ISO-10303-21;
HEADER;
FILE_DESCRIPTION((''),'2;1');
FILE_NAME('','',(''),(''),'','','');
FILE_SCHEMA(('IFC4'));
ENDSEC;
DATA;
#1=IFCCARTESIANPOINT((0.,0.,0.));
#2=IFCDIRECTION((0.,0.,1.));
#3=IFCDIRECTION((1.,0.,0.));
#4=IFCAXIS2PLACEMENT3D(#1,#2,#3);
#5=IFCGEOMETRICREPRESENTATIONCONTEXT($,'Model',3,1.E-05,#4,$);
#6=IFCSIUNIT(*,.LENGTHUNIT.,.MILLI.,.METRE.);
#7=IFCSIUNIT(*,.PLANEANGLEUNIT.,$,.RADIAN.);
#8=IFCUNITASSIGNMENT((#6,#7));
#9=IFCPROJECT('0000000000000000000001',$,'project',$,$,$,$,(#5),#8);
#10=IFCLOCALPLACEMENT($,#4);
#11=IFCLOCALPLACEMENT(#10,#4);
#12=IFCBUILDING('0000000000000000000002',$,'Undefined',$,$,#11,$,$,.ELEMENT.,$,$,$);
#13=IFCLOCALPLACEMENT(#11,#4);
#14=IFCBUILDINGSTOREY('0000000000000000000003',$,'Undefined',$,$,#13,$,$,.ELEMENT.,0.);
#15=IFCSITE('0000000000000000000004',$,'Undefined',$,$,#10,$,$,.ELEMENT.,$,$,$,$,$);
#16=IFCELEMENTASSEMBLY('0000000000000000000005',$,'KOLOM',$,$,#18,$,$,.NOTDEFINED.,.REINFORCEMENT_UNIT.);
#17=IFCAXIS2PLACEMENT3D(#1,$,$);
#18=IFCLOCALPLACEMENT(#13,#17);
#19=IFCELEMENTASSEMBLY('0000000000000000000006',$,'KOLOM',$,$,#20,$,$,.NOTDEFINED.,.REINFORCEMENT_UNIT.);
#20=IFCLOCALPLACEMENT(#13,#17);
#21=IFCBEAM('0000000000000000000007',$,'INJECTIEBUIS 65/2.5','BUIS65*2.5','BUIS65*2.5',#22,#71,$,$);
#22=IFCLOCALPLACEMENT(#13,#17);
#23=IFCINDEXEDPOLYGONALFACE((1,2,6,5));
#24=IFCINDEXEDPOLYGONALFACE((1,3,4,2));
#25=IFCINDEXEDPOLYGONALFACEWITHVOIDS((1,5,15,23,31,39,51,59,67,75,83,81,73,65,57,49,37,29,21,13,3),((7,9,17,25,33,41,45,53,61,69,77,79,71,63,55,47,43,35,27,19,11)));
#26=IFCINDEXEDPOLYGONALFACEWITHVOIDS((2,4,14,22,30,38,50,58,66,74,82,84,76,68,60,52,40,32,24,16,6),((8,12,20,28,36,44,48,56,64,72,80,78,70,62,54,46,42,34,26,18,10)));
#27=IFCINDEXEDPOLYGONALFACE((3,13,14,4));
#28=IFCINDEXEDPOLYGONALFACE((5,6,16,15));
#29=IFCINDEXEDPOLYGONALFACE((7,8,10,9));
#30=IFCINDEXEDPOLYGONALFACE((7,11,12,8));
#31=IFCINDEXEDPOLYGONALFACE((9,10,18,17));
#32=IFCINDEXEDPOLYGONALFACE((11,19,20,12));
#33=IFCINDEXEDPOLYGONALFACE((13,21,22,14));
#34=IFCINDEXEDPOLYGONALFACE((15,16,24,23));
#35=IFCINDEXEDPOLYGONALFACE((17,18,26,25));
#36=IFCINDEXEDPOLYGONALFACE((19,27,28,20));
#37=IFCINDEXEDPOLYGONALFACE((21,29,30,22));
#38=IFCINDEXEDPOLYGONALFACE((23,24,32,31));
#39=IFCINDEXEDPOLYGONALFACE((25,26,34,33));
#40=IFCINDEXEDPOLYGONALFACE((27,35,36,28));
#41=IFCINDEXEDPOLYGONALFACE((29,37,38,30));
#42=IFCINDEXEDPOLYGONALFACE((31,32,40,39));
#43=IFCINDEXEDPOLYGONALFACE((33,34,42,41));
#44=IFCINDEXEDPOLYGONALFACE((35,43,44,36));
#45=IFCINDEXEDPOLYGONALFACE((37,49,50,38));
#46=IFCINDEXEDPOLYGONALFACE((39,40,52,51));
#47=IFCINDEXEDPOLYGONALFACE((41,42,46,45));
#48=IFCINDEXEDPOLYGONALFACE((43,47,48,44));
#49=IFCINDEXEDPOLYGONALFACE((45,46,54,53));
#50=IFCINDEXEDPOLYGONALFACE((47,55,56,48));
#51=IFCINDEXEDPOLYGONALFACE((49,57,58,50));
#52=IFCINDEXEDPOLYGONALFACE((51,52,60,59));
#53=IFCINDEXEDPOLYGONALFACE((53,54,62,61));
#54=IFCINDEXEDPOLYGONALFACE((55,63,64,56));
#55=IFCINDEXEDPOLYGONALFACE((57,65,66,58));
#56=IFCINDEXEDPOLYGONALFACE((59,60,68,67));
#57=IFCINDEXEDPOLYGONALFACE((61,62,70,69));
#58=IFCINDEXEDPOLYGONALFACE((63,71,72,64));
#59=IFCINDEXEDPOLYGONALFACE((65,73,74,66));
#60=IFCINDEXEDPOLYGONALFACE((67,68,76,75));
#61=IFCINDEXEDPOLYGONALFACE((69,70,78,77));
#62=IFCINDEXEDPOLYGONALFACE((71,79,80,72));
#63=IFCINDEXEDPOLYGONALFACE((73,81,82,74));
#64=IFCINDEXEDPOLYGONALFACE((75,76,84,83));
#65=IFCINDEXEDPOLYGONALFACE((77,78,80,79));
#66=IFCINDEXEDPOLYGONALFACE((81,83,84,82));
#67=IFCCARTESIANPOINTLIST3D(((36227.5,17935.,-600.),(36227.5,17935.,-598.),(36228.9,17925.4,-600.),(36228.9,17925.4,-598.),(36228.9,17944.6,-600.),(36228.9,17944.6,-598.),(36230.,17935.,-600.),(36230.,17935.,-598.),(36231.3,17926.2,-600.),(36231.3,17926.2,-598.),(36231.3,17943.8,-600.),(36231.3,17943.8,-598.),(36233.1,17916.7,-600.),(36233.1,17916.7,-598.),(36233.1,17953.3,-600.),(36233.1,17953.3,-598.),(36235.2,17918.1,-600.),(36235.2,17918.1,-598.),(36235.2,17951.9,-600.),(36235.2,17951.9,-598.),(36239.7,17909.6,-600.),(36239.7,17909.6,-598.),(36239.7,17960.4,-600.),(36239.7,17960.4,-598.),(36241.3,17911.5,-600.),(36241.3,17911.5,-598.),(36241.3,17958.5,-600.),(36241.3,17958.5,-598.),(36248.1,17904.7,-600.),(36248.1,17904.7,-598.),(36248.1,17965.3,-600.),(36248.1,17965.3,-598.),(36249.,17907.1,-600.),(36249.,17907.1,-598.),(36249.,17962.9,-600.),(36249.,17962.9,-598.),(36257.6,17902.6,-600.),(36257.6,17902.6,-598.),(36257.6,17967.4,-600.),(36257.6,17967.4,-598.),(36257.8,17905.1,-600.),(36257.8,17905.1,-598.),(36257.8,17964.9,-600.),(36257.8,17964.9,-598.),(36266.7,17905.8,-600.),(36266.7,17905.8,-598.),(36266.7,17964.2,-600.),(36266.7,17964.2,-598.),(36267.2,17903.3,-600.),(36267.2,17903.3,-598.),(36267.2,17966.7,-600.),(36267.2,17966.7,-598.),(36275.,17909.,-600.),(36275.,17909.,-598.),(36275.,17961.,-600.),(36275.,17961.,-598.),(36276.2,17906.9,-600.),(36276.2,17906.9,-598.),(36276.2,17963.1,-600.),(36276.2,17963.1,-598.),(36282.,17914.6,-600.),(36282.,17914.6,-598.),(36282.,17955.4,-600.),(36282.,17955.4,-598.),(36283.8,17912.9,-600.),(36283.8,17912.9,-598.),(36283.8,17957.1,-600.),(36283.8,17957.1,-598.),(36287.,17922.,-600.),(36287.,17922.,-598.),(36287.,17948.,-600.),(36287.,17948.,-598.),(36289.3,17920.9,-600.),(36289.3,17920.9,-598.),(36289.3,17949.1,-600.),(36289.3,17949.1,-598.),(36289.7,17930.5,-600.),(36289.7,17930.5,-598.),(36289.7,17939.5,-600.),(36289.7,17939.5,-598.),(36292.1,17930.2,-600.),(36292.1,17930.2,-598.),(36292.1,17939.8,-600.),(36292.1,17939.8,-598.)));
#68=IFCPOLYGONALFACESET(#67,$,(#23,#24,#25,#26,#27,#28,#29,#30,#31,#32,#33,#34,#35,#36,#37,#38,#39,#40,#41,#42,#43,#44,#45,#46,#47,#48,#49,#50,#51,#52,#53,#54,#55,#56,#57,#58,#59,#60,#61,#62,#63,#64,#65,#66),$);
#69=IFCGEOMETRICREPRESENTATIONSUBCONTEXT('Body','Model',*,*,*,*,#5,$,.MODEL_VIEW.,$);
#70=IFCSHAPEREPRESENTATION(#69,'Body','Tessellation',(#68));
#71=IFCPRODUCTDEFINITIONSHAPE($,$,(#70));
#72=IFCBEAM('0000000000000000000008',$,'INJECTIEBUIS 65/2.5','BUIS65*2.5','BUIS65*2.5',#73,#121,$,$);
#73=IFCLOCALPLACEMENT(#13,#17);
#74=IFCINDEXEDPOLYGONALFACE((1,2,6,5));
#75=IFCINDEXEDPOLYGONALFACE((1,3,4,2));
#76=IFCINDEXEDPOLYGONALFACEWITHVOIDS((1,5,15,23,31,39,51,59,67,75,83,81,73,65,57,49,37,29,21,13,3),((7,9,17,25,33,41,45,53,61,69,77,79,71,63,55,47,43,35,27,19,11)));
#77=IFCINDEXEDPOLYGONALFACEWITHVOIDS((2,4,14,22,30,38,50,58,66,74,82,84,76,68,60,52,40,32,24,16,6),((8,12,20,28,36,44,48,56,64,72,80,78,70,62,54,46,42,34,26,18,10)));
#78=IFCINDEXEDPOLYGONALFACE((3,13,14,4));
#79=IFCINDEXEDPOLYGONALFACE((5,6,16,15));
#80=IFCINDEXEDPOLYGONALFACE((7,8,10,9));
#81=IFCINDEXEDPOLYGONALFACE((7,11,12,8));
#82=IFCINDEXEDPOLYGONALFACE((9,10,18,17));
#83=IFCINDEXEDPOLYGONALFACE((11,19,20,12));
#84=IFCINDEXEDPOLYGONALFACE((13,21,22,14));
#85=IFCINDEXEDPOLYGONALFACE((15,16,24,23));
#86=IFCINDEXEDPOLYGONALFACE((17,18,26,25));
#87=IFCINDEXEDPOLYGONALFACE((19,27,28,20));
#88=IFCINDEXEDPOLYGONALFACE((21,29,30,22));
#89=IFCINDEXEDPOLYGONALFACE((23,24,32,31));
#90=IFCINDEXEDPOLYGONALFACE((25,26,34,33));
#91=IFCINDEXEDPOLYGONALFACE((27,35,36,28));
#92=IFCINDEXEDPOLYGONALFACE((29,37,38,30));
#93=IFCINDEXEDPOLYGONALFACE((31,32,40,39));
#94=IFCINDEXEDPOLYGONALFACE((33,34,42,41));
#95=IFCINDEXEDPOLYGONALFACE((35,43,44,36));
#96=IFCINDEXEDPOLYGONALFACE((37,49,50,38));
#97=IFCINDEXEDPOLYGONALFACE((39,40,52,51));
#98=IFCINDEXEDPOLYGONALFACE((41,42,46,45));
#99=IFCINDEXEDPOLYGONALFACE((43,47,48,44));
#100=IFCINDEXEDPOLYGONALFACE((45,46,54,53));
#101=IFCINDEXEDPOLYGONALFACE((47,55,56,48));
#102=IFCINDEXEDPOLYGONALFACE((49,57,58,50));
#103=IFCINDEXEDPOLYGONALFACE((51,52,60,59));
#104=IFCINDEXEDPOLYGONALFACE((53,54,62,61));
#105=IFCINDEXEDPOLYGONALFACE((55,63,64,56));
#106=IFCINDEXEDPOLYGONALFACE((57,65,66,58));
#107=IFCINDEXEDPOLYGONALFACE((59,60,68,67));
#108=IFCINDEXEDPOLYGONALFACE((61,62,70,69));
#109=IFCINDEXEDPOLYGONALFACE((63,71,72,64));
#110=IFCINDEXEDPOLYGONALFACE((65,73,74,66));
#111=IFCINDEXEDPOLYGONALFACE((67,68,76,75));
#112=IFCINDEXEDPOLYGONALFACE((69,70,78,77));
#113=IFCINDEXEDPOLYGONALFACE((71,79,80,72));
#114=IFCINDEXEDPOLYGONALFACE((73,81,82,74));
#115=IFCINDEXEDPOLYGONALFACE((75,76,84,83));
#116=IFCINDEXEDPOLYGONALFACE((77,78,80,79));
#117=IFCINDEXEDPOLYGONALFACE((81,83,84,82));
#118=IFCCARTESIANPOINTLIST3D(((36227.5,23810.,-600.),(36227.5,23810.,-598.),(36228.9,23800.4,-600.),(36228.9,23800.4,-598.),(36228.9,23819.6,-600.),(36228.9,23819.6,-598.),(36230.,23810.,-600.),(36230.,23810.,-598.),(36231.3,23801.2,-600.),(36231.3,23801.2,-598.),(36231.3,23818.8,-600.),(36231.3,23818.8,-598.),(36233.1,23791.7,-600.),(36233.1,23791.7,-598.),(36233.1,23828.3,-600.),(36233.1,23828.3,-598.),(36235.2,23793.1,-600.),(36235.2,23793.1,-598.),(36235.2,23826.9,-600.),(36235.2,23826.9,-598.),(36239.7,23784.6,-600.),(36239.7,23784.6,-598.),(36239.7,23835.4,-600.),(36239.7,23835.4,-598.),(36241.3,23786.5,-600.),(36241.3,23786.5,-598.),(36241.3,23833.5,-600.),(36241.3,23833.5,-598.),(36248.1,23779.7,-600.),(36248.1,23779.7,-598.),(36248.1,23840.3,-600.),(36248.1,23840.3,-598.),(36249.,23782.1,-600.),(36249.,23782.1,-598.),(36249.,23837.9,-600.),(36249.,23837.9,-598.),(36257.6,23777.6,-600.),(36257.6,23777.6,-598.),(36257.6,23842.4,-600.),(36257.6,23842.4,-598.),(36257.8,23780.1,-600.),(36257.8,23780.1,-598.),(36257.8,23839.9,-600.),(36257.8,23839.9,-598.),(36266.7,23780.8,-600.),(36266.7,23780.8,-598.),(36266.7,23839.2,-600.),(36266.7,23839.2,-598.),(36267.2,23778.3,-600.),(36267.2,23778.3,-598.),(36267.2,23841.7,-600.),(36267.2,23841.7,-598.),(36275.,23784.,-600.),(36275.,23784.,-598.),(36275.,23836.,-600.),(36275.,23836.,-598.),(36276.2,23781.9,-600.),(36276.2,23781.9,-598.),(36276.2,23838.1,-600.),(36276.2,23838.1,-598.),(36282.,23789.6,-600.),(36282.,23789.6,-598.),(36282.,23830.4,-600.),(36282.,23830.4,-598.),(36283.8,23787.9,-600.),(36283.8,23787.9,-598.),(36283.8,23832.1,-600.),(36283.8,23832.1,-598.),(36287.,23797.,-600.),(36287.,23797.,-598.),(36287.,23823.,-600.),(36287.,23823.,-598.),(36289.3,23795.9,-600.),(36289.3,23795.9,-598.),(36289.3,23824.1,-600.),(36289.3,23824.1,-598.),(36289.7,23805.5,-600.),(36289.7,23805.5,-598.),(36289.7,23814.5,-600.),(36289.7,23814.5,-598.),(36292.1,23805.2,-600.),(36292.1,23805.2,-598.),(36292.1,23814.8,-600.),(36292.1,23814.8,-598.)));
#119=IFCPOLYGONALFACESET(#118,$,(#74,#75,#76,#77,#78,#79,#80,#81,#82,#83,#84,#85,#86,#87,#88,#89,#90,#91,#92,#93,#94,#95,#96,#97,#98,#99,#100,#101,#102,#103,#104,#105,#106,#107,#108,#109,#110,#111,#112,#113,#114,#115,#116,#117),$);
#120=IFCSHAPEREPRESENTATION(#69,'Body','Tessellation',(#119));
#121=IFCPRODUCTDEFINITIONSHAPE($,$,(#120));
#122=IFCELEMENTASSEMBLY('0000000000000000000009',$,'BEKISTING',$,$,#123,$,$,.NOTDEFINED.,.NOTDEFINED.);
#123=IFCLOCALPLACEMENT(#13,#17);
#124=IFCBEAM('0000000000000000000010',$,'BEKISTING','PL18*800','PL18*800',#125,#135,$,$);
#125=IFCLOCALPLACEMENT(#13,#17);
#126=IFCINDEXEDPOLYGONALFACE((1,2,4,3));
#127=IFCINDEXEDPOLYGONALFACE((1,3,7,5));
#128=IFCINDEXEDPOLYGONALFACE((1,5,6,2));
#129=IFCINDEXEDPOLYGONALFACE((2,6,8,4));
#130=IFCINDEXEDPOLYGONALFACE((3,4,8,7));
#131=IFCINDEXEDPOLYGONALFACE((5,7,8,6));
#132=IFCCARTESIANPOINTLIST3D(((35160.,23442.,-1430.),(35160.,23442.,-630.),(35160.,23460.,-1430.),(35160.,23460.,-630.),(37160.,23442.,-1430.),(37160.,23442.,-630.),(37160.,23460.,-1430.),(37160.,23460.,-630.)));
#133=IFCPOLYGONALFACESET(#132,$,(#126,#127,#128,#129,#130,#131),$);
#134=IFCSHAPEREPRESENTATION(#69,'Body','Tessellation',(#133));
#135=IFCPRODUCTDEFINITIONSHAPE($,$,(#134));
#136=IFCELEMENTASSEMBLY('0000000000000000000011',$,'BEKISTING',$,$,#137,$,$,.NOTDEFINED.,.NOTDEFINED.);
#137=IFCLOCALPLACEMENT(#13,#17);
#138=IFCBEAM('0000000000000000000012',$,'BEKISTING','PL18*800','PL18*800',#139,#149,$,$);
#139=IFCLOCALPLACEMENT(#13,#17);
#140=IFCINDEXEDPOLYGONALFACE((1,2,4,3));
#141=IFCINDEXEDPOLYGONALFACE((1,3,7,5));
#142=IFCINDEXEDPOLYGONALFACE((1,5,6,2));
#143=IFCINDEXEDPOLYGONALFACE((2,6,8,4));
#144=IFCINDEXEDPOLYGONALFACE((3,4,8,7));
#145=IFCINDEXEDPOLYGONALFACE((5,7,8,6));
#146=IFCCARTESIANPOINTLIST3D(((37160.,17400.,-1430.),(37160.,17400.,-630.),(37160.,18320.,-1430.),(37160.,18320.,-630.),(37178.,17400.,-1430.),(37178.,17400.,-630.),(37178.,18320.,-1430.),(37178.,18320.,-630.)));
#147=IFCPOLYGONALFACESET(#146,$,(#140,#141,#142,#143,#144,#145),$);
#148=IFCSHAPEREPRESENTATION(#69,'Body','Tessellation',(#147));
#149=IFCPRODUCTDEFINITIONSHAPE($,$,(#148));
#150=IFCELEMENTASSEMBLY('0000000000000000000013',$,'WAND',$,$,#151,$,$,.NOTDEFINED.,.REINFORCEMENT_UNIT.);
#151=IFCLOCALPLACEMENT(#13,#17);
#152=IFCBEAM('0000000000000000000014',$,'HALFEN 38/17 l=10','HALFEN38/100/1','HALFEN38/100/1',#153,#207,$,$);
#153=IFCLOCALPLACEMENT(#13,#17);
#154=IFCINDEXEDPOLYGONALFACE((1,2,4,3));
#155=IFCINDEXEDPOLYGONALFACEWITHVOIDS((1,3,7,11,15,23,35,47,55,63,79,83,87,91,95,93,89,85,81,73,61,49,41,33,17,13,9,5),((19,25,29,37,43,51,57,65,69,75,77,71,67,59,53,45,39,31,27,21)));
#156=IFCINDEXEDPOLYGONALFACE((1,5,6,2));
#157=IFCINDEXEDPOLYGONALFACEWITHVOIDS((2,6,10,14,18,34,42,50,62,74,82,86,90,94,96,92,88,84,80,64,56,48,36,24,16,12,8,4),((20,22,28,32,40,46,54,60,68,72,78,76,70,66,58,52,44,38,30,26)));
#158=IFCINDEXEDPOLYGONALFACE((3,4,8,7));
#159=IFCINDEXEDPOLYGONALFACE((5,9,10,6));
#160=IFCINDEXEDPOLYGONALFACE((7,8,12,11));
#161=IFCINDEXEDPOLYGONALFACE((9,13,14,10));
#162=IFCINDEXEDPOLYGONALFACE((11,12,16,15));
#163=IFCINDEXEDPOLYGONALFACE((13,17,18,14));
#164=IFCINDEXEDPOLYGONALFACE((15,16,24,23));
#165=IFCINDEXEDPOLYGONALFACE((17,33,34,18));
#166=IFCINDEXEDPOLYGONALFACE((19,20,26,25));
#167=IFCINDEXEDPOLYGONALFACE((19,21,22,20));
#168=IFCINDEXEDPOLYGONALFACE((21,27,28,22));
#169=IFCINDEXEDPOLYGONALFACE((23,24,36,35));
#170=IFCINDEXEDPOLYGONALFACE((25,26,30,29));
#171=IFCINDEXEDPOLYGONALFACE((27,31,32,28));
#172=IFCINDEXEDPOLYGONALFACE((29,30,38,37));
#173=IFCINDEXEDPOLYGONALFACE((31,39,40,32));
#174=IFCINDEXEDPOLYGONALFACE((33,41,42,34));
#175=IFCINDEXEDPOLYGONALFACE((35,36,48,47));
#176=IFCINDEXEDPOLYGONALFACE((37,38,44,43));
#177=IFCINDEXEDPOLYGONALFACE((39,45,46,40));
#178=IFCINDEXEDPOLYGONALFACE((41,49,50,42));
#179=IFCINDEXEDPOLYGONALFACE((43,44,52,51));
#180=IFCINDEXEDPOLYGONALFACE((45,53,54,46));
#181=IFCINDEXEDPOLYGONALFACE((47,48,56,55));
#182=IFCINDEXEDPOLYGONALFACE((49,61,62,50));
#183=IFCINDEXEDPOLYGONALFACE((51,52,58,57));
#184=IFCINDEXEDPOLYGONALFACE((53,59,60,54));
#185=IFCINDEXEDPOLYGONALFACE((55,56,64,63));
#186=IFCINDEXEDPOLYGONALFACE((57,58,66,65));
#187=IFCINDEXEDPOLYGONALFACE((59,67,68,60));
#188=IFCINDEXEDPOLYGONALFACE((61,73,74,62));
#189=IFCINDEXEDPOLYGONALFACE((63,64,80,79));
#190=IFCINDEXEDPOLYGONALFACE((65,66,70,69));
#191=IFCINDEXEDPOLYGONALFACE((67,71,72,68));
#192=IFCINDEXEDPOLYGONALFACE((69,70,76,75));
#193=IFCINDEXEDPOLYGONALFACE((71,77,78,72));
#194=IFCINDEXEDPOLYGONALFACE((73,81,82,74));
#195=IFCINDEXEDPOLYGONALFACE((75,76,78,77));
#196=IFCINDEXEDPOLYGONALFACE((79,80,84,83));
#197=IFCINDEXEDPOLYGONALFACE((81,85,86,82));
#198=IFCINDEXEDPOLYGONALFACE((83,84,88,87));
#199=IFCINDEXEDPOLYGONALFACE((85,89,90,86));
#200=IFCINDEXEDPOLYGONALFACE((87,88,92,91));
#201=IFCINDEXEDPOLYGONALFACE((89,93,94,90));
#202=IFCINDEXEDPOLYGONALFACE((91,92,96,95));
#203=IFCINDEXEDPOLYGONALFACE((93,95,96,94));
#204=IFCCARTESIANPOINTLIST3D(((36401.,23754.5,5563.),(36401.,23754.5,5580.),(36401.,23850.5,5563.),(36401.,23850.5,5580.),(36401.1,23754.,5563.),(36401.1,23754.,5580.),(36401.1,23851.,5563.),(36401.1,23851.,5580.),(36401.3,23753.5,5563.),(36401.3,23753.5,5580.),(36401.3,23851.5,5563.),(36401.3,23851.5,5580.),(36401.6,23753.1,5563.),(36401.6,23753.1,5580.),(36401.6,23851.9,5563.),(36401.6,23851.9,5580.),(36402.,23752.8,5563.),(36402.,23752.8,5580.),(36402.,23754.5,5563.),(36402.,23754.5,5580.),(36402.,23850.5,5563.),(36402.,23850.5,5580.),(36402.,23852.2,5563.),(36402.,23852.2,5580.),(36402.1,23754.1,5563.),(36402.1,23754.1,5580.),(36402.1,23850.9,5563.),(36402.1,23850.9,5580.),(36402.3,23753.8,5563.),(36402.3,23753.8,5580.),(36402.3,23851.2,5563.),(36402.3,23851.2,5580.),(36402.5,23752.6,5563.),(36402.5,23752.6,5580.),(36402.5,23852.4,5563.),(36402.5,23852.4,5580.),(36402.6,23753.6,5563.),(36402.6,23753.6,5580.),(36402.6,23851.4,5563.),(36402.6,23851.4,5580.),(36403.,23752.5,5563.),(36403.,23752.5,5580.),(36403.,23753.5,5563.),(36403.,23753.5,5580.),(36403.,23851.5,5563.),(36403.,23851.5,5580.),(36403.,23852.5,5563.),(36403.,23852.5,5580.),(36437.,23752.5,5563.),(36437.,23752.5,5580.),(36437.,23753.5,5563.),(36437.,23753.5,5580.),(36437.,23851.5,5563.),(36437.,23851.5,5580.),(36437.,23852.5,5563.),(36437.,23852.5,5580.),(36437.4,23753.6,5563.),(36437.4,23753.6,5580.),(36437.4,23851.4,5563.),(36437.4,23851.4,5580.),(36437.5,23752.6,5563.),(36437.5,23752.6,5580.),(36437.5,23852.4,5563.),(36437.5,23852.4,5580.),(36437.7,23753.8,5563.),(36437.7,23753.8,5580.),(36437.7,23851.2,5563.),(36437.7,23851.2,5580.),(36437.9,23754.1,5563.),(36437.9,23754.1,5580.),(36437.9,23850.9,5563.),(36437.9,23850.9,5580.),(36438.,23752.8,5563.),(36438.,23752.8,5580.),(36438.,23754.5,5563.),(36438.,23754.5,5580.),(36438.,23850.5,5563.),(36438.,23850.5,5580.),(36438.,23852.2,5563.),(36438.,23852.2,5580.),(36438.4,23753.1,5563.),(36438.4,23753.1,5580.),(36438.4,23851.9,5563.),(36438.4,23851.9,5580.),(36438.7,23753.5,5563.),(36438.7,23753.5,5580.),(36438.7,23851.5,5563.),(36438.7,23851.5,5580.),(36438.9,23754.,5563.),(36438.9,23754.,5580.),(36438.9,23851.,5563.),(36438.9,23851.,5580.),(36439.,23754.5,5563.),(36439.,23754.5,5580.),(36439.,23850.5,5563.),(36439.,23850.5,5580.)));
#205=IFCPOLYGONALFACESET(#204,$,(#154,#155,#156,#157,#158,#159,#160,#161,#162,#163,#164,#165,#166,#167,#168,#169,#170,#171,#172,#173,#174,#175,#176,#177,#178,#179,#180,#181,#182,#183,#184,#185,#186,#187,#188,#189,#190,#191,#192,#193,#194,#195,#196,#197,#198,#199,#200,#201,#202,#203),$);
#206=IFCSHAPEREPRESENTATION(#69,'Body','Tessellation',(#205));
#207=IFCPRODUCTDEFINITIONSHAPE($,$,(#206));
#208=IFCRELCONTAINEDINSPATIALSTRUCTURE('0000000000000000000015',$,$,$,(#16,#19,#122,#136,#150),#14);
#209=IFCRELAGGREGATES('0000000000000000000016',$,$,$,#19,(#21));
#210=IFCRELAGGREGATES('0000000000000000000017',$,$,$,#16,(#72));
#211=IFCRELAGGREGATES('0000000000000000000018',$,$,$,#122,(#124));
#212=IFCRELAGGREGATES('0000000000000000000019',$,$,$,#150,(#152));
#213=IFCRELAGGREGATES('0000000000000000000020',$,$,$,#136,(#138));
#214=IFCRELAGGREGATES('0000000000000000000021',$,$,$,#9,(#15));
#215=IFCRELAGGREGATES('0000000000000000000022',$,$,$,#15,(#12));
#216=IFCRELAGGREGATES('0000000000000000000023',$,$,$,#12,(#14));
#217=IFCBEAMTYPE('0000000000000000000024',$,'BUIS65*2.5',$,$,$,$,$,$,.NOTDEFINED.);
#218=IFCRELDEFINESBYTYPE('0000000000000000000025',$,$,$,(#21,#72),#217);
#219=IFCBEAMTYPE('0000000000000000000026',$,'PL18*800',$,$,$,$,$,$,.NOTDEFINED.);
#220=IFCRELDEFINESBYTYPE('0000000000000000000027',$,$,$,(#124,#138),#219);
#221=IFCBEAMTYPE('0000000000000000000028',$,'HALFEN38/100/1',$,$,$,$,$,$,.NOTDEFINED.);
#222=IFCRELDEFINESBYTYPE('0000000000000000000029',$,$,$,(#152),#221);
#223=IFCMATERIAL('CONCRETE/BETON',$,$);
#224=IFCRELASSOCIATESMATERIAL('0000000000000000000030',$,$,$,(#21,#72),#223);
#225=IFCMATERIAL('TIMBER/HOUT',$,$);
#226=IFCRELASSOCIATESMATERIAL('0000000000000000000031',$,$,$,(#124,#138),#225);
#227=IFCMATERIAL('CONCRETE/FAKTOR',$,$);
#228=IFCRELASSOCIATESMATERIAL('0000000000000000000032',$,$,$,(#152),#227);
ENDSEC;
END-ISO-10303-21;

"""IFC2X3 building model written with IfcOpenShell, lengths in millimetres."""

from ifc_helpers import new_model, si_unit, frame, frame_2d, origin_with_axes, place, context, subcontext, project, spatial, rectangle, hollow_rectangle, hollow_circle, extrude, material, type_object, element, aggregate, save


model = new_model("IFC2X3")

# Units and contexts
model_context = context("Model", 3, precision=1e-05, world=origin_with_axes())
body_context = subcontext(model_context, "Body", "Model", "MODEL_VIEW")
ifc_project = project(units=[si_unit("LENGTHUNIT", "METRE", prefix="MILLI"), si_unit("PLANEANGLEUNIT", "RADIAN")], contexts=[model_context])

# Site, building, storey
site_placement = place(None, origin_with_axes())
site = spatial("IfcSite", under=ifc_project, at=site_placement, Name="Undefined", CompositionType="ELEMENT")
building_placement = place(site_placement, origin_with_axes())
building = spatial("IfcBuilding", under=site, at=building_placement, Name="Undefined", CompositionType="ELEMENT")
storey_placement = place(building_placement, origin_with_axes())
storey = spatial("IfcBuildingStorey", under=building, at=storey_placement, Name="Undefined", CompositionType="ELEMENT", Elevation=0.0)

# Element assemblies
ifc_material_1 = material(Name="CONCRETE/FAKTOR")
assembly_1_placement = place(storey_placement, origin_with_axes())
assembly_1 = element("IfcElementAssembly", 1, at=assembly_1_placement, inside=storey, Name="KOLOM", AssemblyPlace="NOTDEFINED", PredefinedType="REINFORCEMENT_UNIT")
assembly_2_placement = place(storey_placement, origin_with_axes())
assembly_2 = element("IfcElementAssembly", 2, at=assembly_2_placement, inside=storey, Name="KOLOM", AssemblyPlace="NOTDEFINED", PredefinedType="REINFORCEMENT_UNIT")

# Beams
ifc_material_2 = material(Name="CONCRETE/BETON")
beam_type_1 = type_object("IfcBeamType", Name="BUIS65*2.5", PredefinedType="NOTDEFINED")
beam_1_placement = place(assembly_2_placement, frame((36260.0, 17935.0, -600.0), z_axis=(0.0, 1.0, 0.0), x_axis=(0.0, 0.0, 1.0)))
beam_1 = element("IfcBeam", 3, at=beam_1_placement, type_object=beam_type_1, material=ifc_material_2, Name="INJECTIEBUIS 65/2.5", Description="BUIS65*2.5", ObjectType="BUIS65*2.5", context=body_context, shape_type="SweptSolid", body=[
    extrude(hollow_circle(Radius=32.5, WallThickness=2.5, at=frame_2d((0.0, 0.0), x_axis=(1.0, 0.0))), frame((2.0, 0.0, 0.0), z_axis=(-1.0, 0.0, 0.0), x_axis=(0.0, -1.0, 0.0)), (0.0, 0.0, 1.0), 2.0),
])
aggregate(assembly_2, [beam_1])
beam_2_placement = place(assembly_1_placement, frame((36260.0, 23810.0, -600.0), z_axis=(0.0, 1.0, 0.0), x_axis=(0.0, 0.0, 1.0)))
beam_2 = element("IfcBeam", 4, at=beam_2_placement, type_object=beam_type_1, material=ifc_material_2, Name="INJECTIEBUIS 65/2.5", Description="BUIS65*2.5", ObjectType="BUIS65*2.5", context=body_context, shape_type="SweptSolid", body=[
    extrude(hollow_circle(Radius=32.5, WallThickness=2.5, at=frame_2d((0.0, 0.0), x_axis=(1.0, 0.0))), frame((2.0, 0.0, 0.0), z_axis=(-1.0, 0.0, 0.0), x_axis=(0.0, -1.0, 0.0)), (0.0, 0.0, 1.0), 2.0),
])
aggregate(assembly_1, [beam_2])

# Element assemblies, beams
assembly_3_placement = place(storey_placement, origin_with_axes())
assembly_3 = element("IfcElementAssembly", 5, at=assembly_3_placement, inside=storey, Name="BEKISTING", AssemblyPlace="NOTDEFINED", PredefinedType="NOTDEFINED")
ifc_material_3 = material(Name="TIMBER/HOUT")
beam_type_2 = type_object("IfcBeamType", Name="PL18*800", PredefinedType="NOTDEFINED")
beam_3_placement = place(assembly_3_placement, frame((37160.0, 23451.0, -1030.0), z_axis=(0.0, 0.0, -1.0), x_axis=(-1.0, 0.0, 0.0)))
beam_3 = element("IfcBeam", 6, at=beam_3_placement, type_object=beam_type_2, material=ifc_material_3, Name="BEKISTING", Description="PL18*800", ObjectType="PL18*800", context=body_context, shape_type="SweptSolid", body=[
    extrude(rectangle(XDim=18.0, YDim=800.0, at=frame_2d((0.0, 0.0), x_axis=(1.0, 0.0))), frame((2000.0, 0.0, 0.0), z_axis=(-1.0, 0.0, 0.0), x_axis=(0.0, -1.0, 0.0)), (0.0, 0.0, 1.0), 2000.0),
])
aggregate(assembly_3, [beam_3])
assembly_4_placement = place(storey_placement, origin_with_axes())
assembly_4 = element("IfcElementAssembly", 7, at=assembly_4_placement, inside=storey, Name="BEKISTING", AssemblyPlace="NOTDEFINED", PredefinedType="NOTDEFINED")
beam_4_placement = place(assembly_4_placement, frame((37169.0, 18320.0, -1030.0), z_axis=(0.0, 0.0, 1.0), x_axis=(0.0, -1.0, 0.0)))
beam_4 = element("IfcBeam", 8, at=beam_4_placement, type_object=beam_type_2, material=ifc_material_3, Name="BEKISTING", Description="PL18*800", ObjectType="PL18*800", context=body_context, shape_type="SweptSolid", body=[
    extrude(rectangle(XDim=18.0, YDim=800.0, at=frame_2d((0.0, 0.0), x_axis=(1.0, 0.0))), frame((920.0, 0.0, 0.0), z_axis=(-1.0, 0.0, 0.0), x_axis=(0.0, -1.0, 0.0)), (0.0, 0.0, 1.0), 920.0),
])

# Element assembly, beam
assembly_5_placement = place(storey_placement, origin_with_axes())
assembly_5 = element("IfcElementAssembly", 9, at=assembly_5_placement, inside=storey, Name="WAND", AssemblyPlace="NOTDEFINED", PredefinedType="REINFORCEMENT_UNIT")
beam_type_3 = type_object("IfcBeamType", Name="HALFEN38/100/1", PredefinedType="NOTDEFINED")
beam_5_placement = place(assembly_5_placement, frame((36420.0, 23802.5, 5580.0), z_axis=(1.0, 0.0, 0.0), x_axis=(0.0, 0.0, -1.0)))
beam_5 = element("IfcBeam", 10, at=beam_5_placement, type_object=beam_type_3, material=ifc_material_1, Name="HALFEN 38/17 l=10", Description="HALFEN38/100/1", ObjectType="HALFEN38/100/1", context=body_context, shape_type="SweptSolid", body=[
    extrude(hollow_rectangle(XDim=100.0, YDim=38.0, WallThickness=1.0, InnerFilletRadius=1.0, OuterFilletRadius=2.0, at=frame_2d((0.0, 0.0), x_axis=(1.0, 0.0))), frame((17.0, 0.0, 0.0), z_axis=(-1.0, 0.0, 0.0), x_axis=(0.0, -1.0, 0.0)), (0.0, 0.0, 1.0), 17.0),
])

aggregate(assembly_5, [beam_5])

aggregate(assembly_4, [beam_4])

save(model, "model.ifc")
